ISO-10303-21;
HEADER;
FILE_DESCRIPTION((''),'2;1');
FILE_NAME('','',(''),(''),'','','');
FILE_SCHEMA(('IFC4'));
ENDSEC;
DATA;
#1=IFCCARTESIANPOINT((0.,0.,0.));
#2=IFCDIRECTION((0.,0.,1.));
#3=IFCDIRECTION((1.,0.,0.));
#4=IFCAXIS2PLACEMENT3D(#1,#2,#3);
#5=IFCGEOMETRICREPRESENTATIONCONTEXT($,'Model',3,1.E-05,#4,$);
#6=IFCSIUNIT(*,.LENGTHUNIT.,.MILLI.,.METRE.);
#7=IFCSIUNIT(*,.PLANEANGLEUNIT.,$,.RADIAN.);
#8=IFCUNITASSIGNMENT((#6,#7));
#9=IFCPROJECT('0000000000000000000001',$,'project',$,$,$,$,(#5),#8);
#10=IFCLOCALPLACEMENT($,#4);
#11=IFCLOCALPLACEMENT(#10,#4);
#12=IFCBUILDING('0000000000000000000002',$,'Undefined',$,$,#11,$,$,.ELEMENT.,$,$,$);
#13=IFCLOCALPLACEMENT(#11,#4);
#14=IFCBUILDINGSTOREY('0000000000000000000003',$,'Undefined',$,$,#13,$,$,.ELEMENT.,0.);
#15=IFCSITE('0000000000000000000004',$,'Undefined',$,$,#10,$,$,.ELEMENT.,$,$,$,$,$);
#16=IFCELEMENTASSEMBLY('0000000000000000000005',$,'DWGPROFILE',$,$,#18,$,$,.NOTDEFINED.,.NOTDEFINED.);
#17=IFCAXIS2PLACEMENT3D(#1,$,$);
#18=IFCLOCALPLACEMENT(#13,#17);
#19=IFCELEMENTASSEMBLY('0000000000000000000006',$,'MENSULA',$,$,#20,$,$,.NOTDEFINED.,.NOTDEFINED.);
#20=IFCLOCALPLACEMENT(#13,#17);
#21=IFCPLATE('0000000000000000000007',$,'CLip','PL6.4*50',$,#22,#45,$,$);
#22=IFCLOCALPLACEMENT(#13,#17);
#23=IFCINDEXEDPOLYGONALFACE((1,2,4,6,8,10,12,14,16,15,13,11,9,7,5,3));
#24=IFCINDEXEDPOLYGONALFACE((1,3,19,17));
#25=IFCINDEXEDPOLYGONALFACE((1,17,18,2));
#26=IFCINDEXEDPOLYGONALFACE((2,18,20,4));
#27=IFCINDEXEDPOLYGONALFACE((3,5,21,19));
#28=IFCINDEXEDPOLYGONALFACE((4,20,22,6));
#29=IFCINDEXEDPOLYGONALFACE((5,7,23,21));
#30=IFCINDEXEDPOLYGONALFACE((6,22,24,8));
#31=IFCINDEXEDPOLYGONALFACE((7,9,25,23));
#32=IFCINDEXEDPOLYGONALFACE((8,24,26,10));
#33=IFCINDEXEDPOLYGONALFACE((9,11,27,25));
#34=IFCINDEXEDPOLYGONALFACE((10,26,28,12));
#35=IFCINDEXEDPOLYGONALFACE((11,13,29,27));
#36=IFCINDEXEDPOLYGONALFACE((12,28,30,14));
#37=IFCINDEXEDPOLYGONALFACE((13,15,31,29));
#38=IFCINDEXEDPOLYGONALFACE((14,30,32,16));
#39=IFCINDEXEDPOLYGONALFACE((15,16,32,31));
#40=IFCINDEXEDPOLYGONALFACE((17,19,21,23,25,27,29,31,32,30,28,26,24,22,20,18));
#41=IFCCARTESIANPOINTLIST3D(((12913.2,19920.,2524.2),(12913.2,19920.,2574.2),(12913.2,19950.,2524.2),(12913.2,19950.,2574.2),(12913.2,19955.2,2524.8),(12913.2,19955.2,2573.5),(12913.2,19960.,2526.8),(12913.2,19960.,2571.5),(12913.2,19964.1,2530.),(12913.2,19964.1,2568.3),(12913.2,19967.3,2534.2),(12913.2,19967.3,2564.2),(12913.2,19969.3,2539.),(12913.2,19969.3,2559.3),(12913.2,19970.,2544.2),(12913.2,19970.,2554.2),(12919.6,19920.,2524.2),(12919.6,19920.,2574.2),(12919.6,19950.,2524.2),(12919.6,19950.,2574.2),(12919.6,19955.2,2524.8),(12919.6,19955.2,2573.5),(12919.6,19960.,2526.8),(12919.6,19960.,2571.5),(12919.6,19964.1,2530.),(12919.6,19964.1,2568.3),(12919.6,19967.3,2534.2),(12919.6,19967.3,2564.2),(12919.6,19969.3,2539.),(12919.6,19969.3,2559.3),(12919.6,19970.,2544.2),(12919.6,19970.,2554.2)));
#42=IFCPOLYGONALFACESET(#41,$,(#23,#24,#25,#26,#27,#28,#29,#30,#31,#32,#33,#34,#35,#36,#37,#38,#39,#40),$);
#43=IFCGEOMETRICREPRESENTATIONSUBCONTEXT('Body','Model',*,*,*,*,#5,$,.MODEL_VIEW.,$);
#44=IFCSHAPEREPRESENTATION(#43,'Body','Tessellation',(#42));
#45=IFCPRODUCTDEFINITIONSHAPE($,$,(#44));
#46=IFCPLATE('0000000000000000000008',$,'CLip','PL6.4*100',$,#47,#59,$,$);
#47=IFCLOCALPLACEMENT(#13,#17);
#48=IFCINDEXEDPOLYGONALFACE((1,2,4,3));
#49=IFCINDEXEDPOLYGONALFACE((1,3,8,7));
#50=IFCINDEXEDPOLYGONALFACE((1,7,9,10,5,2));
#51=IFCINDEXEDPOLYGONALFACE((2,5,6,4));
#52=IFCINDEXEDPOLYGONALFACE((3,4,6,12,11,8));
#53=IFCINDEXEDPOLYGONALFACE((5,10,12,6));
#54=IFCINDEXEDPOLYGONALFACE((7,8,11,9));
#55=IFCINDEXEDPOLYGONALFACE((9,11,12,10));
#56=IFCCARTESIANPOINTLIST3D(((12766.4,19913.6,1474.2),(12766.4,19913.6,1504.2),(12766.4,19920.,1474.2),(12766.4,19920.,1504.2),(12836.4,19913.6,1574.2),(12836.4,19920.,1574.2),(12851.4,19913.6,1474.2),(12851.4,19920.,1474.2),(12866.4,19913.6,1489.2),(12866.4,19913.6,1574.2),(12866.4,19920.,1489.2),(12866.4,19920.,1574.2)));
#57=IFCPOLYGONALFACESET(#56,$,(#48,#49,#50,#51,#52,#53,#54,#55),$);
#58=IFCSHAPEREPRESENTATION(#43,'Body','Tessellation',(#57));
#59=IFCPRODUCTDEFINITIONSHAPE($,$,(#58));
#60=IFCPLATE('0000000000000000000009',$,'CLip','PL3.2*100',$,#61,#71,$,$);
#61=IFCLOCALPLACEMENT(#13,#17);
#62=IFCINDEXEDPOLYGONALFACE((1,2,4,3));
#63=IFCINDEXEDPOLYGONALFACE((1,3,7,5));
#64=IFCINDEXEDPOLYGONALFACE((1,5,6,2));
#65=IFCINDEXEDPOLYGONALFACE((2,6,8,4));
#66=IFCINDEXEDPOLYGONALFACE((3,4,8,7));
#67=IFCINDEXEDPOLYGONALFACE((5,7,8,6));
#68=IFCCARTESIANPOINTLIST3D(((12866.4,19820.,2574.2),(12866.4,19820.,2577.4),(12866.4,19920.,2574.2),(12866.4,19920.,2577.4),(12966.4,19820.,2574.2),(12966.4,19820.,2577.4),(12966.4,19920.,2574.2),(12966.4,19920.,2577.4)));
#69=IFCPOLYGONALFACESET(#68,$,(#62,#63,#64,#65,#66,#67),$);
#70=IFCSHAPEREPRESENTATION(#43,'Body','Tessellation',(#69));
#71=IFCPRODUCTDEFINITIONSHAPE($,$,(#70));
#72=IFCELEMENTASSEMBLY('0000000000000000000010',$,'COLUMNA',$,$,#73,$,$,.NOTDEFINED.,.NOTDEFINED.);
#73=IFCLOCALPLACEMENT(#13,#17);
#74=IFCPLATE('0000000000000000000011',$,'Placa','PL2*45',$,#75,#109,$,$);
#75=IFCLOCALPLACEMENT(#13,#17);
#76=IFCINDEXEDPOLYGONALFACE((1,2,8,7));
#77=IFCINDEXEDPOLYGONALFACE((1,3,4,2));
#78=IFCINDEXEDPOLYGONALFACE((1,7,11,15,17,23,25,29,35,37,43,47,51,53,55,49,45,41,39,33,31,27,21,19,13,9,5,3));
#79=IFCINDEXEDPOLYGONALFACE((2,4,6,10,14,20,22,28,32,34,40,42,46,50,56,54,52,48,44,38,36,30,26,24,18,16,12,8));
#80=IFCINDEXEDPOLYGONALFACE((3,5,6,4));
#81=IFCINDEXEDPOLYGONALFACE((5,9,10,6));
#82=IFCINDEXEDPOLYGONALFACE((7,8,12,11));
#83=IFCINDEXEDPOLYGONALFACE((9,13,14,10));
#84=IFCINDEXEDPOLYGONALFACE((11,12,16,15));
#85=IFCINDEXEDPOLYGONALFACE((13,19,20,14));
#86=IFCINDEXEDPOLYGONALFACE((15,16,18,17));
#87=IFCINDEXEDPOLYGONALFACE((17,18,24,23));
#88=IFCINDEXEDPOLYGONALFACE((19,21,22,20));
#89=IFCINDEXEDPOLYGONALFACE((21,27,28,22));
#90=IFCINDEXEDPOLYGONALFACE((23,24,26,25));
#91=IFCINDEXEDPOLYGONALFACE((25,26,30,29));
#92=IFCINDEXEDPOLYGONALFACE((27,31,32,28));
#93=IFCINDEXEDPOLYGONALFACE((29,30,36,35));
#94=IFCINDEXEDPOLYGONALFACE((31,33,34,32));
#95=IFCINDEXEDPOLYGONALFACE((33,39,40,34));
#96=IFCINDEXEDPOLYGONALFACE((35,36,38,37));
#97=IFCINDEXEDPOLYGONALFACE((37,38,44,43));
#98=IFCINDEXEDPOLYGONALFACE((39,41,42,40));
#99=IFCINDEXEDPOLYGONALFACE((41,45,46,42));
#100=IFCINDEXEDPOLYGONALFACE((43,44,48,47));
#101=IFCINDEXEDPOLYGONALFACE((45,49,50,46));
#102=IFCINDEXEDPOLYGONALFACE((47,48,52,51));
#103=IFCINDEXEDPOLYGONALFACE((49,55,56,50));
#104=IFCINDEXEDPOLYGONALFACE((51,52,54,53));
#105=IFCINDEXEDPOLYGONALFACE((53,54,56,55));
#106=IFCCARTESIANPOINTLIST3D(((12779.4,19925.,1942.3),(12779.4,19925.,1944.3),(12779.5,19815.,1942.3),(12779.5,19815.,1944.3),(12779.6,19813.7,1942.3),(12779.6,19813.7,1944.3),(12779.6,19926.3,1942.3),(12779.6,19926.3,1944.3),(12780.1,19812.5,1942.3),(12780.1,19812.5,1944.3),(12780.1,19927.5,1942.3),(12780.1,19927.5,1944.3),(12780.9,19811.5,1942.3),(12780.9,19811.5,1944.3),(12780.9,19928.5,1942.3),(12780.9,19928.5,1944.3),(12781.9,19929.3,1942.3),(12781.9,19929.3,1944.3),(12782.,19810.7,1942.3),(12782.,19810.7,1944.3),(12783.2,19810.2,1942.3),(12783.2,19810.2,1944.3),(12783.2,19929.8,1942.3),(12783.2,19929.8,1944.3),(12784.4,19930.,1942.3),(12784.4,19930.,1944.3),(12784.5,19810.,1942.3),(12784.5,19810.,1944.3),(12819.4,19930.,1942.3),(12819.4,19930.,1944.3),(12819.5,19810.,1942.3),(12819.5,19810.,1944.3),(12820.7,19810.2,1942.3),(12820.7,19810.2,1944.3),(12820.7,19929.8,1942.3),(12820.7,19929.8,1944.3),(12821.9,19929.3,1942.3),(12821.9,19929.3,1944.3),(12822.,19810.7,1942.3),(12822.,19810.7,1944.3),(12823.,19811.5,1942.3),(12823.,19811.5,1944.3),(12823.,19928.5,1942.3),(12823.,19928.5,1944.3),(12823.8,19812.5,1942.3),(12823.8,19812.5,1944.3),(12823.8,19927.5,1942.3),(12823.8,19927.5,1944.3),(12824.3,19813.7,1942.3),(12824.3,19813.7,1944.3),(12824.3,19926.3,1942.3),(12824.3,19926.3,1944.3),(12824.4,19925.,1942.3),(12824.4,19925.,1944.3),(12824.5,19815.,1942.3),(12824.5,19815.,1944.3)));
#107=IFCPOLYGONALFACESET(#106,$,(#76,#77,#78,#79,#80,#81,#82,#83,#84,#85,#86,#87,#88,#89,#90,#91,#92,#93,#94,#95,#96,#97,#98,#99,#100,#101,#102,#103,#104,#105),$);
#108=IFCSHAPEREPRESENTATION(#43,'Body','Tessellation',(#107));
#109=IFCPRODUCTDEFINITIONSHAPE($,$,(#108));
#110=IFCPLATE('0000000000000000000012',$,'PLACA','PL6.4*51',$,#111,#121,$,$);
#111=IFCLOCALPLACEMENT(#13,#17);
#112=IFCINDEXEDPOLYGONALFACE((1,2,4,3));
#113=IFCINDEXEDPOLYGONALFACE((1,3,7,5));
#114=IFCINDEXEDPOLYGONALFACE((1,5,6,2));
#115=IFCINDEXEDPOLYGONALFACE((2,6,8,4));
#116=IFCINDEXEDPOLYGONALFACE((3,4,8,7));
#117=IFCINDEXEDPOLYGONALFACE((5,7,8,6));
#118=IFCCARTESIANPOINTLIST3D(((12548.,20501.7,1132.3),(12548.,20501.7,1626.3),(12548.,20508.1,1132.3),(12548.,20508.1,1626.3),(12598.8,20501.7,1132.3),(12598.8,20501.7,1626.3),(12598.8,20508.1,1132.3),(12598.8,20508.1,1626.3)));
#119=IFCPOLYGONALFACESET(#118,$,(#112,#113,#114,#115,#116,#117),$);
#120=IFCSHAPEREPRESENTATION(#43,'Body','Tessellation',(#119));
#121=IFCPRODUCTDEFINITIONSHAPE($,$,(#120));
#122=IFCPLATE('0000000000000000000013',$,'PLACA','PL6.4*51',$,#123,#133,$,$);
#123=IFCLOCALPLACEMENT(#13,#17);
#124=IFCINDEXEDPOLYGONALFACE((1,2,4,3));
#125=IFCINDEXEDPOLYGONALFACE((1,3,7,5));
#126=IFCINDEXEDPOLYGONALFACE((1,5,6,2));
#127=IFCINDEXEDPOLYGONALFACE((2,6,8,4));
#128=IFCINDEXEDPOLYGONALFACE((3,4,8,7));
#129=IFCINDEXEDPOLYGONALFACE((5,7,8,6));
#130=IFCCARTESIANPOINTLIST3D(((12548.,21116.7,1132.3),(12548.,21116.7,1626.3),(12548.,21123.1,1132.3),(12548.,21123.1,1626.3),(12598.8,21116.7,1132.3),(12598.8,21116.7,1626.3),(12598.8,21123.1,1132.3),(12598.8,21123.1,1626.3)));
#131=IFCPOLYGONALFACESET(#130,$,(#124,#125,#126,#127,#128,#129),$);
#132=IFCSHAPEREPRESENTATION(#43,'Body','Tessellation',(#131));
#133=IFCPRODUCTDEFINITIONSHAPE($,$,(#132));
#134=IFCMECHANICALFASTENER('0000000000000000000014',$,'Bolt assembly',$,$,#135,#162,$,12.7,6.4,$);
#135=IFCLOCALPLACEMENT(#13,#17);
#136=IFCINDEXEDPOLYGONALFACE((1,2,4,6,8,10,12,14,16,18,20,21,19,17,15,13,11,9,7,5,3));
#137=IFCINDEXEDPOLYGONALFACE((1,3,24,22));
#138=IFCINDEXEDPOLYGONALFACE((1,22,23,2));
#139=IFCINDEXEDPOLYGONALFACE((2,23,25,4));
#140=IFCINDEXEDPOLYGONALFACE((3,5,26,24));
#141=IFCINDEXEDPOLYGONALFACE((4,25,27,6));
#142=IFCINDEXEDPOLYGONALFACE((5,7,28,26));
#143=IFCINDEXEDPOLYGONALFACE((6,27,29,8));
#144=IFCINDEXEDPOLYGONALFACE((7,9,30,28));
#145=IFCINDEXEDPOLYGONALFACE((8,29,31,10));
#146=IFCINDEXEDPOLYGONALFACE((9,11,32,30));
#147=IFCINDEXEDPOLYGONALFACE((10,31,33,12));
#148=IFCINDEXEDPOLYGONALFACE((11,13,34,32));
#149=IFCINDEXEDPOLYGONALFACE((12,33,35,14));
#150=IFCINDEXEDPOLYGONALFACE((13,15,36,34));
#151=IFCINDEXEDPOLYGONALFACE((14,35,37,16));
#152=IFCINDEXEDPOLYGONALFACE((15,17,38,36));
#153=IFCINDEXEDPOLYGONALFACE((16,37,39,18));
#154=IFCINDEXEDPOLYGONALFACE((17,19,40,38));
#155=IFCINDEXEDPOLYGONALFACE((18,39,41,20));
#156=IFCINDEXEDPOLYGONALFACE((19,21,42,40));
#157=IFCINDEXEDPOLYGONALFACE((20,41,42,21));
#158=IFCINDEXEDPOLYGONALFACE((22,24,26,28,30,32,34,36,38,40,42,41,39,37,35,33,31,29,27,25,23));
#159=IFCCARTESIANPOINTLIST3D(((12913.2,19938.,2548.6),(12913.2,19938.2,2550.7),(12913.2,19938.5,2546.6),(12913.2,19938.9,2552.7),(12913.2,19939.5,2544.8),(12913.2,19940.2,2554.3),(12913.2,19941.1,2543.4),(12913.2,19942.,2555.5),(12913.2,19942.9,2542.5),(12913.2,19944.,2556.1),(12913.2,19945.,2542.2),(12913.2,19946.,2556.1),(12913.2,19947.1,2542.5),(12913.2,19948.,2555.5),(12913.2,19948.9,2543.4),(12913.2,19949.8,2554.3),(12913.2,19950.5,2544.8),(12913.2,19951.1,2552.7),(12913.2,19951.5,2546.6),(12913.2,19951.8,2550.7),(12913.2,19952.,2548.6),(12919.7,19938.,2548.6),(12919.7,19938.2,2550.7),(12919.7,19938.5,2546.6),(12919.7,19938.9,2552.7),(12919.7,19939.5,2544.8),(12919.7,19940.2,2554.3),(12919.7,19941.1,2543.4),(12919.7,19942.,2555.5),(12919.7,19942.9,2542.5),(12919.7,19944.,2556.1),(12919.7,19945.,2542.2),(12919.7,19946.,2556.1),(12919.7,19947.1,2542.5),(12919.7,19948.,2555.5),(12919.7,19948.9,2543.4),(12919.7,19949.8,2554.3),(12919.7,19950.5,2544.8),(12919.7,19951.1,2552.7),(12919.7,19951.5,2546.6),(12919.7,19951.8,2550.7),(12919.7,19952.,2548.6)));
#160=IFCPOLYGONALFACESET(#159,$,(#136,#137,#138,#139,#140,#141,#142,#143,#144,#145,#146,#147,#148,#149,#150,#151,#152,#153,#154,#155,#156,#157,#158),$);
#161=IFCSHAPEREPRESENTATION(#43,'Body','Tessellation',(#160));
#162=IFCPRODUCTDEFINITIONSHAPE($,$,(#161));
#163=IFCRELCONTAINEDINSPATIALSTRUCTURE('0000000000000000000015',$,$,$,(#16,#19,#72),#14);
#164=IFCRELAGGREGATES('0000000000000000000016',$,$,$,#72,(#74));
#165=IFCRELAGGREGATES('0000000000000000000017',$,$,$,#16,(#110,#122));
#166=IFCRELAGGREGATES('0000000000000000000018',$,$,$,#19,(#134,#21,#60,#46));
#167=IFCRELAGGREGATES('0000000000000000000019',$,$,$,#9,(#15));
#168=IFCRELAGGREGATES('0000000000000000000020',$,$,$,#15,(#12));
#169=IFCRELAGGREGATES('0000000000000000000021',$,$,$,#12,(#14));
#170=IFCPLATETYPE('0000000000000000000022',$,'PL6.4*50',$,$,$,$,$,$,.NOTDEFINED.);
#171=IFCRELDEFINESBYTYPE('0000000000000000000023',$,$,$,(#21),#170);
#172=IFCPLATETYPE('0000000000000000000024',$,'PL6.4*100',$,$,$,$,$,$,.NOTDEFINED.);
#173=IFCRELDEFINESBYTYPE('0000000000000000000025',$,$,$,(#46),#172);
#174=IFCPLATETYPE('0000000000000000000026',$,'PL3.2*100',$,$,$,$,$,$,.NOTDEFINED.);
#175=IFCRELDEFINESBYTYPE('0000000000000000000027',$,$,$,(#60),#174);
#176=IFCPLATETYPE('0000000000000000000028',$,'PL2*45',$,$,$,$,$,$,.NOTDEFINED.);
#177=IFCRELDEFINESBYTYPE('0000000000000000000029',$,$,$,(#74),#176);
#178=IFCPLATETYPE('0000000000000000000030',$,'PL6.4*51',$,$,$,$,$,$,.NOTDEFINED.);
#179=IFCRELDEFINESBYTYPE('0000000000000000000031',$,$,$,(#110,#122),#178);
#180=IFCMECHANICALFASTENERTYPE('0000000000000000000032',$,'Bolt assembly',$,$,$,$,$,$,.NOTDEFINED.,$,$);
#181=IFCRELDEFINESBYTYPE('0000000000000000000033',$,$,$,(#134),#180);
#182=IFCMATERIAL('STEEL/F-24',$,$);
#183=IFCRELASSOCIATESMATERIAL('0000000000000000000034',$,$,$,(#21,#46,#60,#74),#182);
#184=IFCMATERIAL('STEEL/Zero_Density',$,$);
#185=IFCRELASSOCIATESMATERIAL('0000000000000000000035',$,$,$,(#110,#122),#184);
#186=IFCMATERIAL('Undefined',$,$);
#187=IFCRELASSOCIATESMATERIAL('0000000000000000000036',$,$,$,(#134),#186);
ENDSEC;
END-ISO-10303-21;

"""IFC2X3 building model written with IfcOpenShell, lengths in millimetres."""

from ifc_helpers import new_model, si_unit, frame, frame_2d, origin_with_axes, origin_2d_with_axis, place, context, subcontext, project, spatial, polyline, circle_curve, parameter, trimmed, segment, composite_curve, circle, outline, extrude, source, transform, mapped, material, type_object, element, aggregate, save


model = new_model("IFC2X3")

# Units and contexts
model_context = context("Model", 3, precision=1e-05, world=origin_with_axes())
body_context = subcontext(model_context, "Body", "Model", "MODEL_VIEW")
ifc_project = project(units=[si_unit("LENGTHUNIT", "METRE", prefix="MILLI"), si_unit("PLANEANGLEUNIT", "RADIAN")], contexts=[model_context])

# Site, building, storey
site_placement = place(None, origin_with_axes())
site = spatial("IfcSite", under=ifc_project, at=site_placement, Name="Undefined", CompositionType="ELEMENT")
building_placement = place(site_placement, origin_with_axes())
building = spatial("IfcBuilding", under=site, at=building_placement, Name="Undefined", CompositionType="ELEMENT")
storey_placement = place(building_placement, origin_with_axes())
storey = spatial("IfcBuildingStorey", under=building, at=storey_placement, Name="Undefined", CompositionType="ELEMENT", Elevation=0.0)

# Element assembly
assembly_1_placement = place(storey_placement, origin_with_axes())
assembly_1 = element("IfcElementAssembly", 1, at=assembly_1_placement, inside=storey, Name="DWGPROFILE", AssemblyPlace="NOTDEFINED", PredefinedType="NOTDEFINED")
ifc_material_1 = material(Name="STEEL/Zero_Density")

# Element assembly, plates
assembly_2_placement = place(storey_placement, origin_with_axes())
assembly_2 = element("IfcElementAssembly", 2, at=assembly_2_placement, inside=storey, Name="MENSULA", AssemblyPlace="NOTDEFINED", PredefinedType="NOTDEFINED")
ifc_material_2 = material(Name="STEEL/F-24")
plate_type_1 = type_object("IfcPlateType", Name="PL6.4*50", PredefinedType="NOTDEFINED")
plate_1_placement = place(assembly_2_placement, frame((12916.4, 19920.0, 2574.2), z_axis=(-1.0, 0.0, 0.0), x_axis=(0.0, 1.0, 0.0)))
plate_1 = element("IfcPlate", 3, at=plate_1_placement, type_object=plate_type_1, material=ifc_material_2, Name="CLip", Description="PL6.4*50", context=body_context, shape_type="SweptSolid", body=[
    extrude(outline(composite_curve([segment(polyline([(0.0, 0.0), (30.0, 0.0)]), True, "CONTINUOUS"), segment(trimmed(circle_curve(frame_2d((30.0, 20.0), x_axis=(0.0, -1.0)), 20.0), [parameter(0.0)], [parameter(1.570796)], True, "PARAMETER"), True, "CONTINUOUS"), segment(polyline([(50.0, 20.0), (50.0, 30.0)]), True, "CONTINUOUS"), segment(trimmed(circle_curve(frame_2d((30.0, 30.0), x_axis=(1.0, 0.0)), 20.0), [parameter(0.0)], [parameter(1.570796)], True, "PARAMETER"), True, "CONTINUOUS"), segment(polyline([(30.0, 50.0), (0.0, 50.0), (0.0, 0.0)]), True, "CONTINUOUS")], self_intersect=True)), frame((0.0, 0.0, -3.2), z_axis=(0.0, 0.0, 1.0), x_axis=(1.0, 0.0, 0.0)), (0.0, 0.0, 1.0), 6.4),
])
plate_type_2 = type_object("IfcPlateType", Name="PL6.4*100", PredefinedType="NOTDEFINED")
plate_2_placement = place(assembly_2_placement, frame((12866.4, 19916.8, 1474.2), z_axis=(0.0, 1.0, 0.0), x_axis=(-1.0, 0.0, 0.0)))
plate_2 = element("IfcPlate", 4, at=plate_2_placement, type_object=plate_type_2, material=ifc_material_2, Name="CLip", Description="PL6.4*100", context=body_context, shape_type="SweptSolid", body=[
    extrude(outline(polyline([(0.0, 15.0), (15.0, 0.0), (100.0, 0.0), (100.0, 30.0), (30.0, 100.0), (0.0, 100.0), (0.0, 15.0)])), frame((0.0, 0.0, -3.2), z_axis=(0.0, 0.0, 1.0), x_axis=(1.0, 0.0, 0.0)), (0.0, 0.0, 1.0), 6.4),
])
plate_type_3 = type_object("IfcPlateType", Name="PL3.2*100", PredefinedType="NOTDEFINED")
plate_3_placement = place(assembly_2_placement, frame((12866.4, 19920.0, 2575.8), z_axis=(0.0, 0.0, 1.0), x_axis=(0.0, -1.0, 0.0)))
plate_3 = element("IfcPlate", 5, at=plate_3_placement, type_object=plate_type_3, material=ifc_material_2, Name="CLip", Description="PL3.2*100", context=body_context, shape_type="SweptSolid", body=[
    extrude(outline(polyline([(0.0, 0.0), (100.0, 0.0), (100.0, 100.0), (0.0, 100.0), (0.0, 0.0)])), frame((0.0, 0.0, -1.6), z_axis=(0.0, 0.0, 1.0), x_axis=(1.0, 0.0, 0.0)), (0.0, 0.0, 1.0), 3.2),
])

# Element assembly, plate
assembly_3_placement = place(storey_placement, origin_with_axes())
assembly_3 = element("IfcElementAssembly", 6, at=assembly_3_placement, inside=storey, Name="COLUMNA", AssemblyPlace="NOTDEFINED", PredefinedType="NOTDEFINED")
plate_type_4 = type_object("IfcPlateType", Name="PL2*45", PredefinedType="NOTDEFINED")
plate_4_placement = place(assembly_3_placement, frame((12824.4, 19930.0, 1943.3), z_axis=(0.000121, -0.000003, 1.0), x_axis=(-1.0, 0.000071, 0.000121)))
plate_4 = element("IfcPlate", 7, at=plate_4_placement, type_object=plate_type_4, material=ifc_material_2, Name="Placa", Description="PL2*45", context=body_context, shape_type="SweptSolid", body=[
    extrude(outline(composite_curve([segment(trimmed(circle_curve(frame_2d((5.0, 5.0), x_axis=(-1.0, -0.000156)), 5.0), [parameter(0.0)], [parameter(1.57064)], True, "PARAMETER"), True, "CONTINUOUS"), segment(polyline([(5.0, 0.0), (40.0, 0.0)]), True, "CONTINUOUS"), segment(trimmed(circle_curve(frame_2d((40.0, 5.0), x_axis=(0.0, -1.0)), 5.0), [parameter(0.0)], [parameter(1.570952)], True, "PARAMETER"), True, "CONTINUOUS"), segment(polyline([(45.0, 5.0), (45.0, 115.0)]), True, "CONTINUOUS"), segment(trimmed(circle_curve(frame_2d((40.0, 115.0), x_axis=(1.0, 0.000156)), 5.0), [parameter(0.0)], [parameter(1.57071)], True, "PARAMETER"), True, "CONTINUOUS"), segment(polyline([(40.0, 120.0), (5.0, 120.0)]), True, "CONTINUOUS"), segment(trimmed(circle_curve(frame_2d((5.0, 115.0), x_axis=(-0.000069, 1.0)), 5.0), [parameter(0.0)], [parameter(1.570883)], True, "PARAMETER"), True, "CONTINUOUS"), segment(polyline([(0.0, 115.0), (0.0, 5.0)]), True, "CONTINUOUS")], self_intersect=True)), frame((0.0, 0.0, -1.0), z_axis=(0.0, 0.0, 1.0), x_axis=(1.0, 0.0, 0.0)), (0.0, 0.0, 1.0), 2.0),
])
aggregate(assembly_3, [plate_4])

# Plates
plate_type_5 = type_object("IfcPlateType", Name="PL6.4*51", PredefinedType="NOTDEFINED")
plate_5_placement = place(assembly_1_placement, frame((12548.0, 20504.9, 1626.3), z_axis=(0.0, 1.0, 0.0), x_axis=(1.0, 0.0, 0.0)))
plate_5 = element("IfcPlate", 8, at=plate_5_placement, type_object=plate_type_5, material=ifc_material_1, Name="PLACA", Description="PL6.4*51", context=body_context, shape_type="SweptSolid", body=[
    extrude(outline(polyline([(0.0, 0.0), (50.8, 0.0), (50.8, 494.0), (0.0, 494.0), (0.0, 0.0)])), frame((0.0, 0.0, -3.2), z_axis=(0.0, 0.0, 1.0), x_axis=(1.0, 0.0, 0.0)), (0.0, 0.0, 1.0), 6.4),
])
plate_6_placement = place(assembly_1_placement, frame((12548.0, 21119.9, 1626.3), z_axis=(0.0, 1.0, 0.0), x_axis=(1.0, 0.0, 0.0)))
plate_6 = element("IfcPlate", 9, at=plate_6_placement, type_object=plate_type_5, material=ifc_material_1, Name="PLACA", Description="PL6.4*51", context=body_context, shape_type="SweptSolid", body=[
    extrude(outline(polyline([(0.0, 0.0), (50.8, 0.0), (50.8, 494.0), (0.0, 494.0), (0.0, 0.0)])), frame((0.0, 0.0, -3.2), z_axis=(0.0, 0.0, 1.0), x_axis=(1.0, 0.0, 0.0)), (0.0, 0.0, 1.0), 6.4),
])
aggregate(assembly_1, [plate_5, plate_6])

# Mechanical fastener
ifc_material_3 = material(Name="Undefined")
mechanical_fastener_type = type_object("IfcMechanicalFastenerType", Name="Bolt assembly")
shared_shape = source(origin_with_axes(), body_context, "Body", "SweptSolid", [
    extrude(circle(Radius=7.0, at=origin_2d_with_axis()), frame((0.0, -1.0, 0.0), z_axis=(0.0, 1.0, 0.0), x_axis=(1.0, 0.0, 0.0)), (0.0, 0.0, 1.0), 6.5),
])
mechanical_fastener_placement = place(assembly_2_placement, frame((12914.3, 19945.0, 2549.2), z_axis=(0.0, -1.0, 0.0), x_axis=(0.0, 0.000001, -1.0)))
mechanical_fastener = element("IfcMechanicalFastener", 10, at=mechanical_fastener_placement, type_object=mechanical_fastener_type, material=ifc_material_3, Name="Bolt assembly", NominalDiameter=12.7, NominalLength=6.4, context=body_context, shape_type="MappedRepresentation", body=[
    mapped(shared_shape, transform((0.0, 0.0, 0.0))),
])
aggregate(assembly_2, [mechanical_fastener, plate_1, plate_3, plate_2])

save(model, "model.ifc")
